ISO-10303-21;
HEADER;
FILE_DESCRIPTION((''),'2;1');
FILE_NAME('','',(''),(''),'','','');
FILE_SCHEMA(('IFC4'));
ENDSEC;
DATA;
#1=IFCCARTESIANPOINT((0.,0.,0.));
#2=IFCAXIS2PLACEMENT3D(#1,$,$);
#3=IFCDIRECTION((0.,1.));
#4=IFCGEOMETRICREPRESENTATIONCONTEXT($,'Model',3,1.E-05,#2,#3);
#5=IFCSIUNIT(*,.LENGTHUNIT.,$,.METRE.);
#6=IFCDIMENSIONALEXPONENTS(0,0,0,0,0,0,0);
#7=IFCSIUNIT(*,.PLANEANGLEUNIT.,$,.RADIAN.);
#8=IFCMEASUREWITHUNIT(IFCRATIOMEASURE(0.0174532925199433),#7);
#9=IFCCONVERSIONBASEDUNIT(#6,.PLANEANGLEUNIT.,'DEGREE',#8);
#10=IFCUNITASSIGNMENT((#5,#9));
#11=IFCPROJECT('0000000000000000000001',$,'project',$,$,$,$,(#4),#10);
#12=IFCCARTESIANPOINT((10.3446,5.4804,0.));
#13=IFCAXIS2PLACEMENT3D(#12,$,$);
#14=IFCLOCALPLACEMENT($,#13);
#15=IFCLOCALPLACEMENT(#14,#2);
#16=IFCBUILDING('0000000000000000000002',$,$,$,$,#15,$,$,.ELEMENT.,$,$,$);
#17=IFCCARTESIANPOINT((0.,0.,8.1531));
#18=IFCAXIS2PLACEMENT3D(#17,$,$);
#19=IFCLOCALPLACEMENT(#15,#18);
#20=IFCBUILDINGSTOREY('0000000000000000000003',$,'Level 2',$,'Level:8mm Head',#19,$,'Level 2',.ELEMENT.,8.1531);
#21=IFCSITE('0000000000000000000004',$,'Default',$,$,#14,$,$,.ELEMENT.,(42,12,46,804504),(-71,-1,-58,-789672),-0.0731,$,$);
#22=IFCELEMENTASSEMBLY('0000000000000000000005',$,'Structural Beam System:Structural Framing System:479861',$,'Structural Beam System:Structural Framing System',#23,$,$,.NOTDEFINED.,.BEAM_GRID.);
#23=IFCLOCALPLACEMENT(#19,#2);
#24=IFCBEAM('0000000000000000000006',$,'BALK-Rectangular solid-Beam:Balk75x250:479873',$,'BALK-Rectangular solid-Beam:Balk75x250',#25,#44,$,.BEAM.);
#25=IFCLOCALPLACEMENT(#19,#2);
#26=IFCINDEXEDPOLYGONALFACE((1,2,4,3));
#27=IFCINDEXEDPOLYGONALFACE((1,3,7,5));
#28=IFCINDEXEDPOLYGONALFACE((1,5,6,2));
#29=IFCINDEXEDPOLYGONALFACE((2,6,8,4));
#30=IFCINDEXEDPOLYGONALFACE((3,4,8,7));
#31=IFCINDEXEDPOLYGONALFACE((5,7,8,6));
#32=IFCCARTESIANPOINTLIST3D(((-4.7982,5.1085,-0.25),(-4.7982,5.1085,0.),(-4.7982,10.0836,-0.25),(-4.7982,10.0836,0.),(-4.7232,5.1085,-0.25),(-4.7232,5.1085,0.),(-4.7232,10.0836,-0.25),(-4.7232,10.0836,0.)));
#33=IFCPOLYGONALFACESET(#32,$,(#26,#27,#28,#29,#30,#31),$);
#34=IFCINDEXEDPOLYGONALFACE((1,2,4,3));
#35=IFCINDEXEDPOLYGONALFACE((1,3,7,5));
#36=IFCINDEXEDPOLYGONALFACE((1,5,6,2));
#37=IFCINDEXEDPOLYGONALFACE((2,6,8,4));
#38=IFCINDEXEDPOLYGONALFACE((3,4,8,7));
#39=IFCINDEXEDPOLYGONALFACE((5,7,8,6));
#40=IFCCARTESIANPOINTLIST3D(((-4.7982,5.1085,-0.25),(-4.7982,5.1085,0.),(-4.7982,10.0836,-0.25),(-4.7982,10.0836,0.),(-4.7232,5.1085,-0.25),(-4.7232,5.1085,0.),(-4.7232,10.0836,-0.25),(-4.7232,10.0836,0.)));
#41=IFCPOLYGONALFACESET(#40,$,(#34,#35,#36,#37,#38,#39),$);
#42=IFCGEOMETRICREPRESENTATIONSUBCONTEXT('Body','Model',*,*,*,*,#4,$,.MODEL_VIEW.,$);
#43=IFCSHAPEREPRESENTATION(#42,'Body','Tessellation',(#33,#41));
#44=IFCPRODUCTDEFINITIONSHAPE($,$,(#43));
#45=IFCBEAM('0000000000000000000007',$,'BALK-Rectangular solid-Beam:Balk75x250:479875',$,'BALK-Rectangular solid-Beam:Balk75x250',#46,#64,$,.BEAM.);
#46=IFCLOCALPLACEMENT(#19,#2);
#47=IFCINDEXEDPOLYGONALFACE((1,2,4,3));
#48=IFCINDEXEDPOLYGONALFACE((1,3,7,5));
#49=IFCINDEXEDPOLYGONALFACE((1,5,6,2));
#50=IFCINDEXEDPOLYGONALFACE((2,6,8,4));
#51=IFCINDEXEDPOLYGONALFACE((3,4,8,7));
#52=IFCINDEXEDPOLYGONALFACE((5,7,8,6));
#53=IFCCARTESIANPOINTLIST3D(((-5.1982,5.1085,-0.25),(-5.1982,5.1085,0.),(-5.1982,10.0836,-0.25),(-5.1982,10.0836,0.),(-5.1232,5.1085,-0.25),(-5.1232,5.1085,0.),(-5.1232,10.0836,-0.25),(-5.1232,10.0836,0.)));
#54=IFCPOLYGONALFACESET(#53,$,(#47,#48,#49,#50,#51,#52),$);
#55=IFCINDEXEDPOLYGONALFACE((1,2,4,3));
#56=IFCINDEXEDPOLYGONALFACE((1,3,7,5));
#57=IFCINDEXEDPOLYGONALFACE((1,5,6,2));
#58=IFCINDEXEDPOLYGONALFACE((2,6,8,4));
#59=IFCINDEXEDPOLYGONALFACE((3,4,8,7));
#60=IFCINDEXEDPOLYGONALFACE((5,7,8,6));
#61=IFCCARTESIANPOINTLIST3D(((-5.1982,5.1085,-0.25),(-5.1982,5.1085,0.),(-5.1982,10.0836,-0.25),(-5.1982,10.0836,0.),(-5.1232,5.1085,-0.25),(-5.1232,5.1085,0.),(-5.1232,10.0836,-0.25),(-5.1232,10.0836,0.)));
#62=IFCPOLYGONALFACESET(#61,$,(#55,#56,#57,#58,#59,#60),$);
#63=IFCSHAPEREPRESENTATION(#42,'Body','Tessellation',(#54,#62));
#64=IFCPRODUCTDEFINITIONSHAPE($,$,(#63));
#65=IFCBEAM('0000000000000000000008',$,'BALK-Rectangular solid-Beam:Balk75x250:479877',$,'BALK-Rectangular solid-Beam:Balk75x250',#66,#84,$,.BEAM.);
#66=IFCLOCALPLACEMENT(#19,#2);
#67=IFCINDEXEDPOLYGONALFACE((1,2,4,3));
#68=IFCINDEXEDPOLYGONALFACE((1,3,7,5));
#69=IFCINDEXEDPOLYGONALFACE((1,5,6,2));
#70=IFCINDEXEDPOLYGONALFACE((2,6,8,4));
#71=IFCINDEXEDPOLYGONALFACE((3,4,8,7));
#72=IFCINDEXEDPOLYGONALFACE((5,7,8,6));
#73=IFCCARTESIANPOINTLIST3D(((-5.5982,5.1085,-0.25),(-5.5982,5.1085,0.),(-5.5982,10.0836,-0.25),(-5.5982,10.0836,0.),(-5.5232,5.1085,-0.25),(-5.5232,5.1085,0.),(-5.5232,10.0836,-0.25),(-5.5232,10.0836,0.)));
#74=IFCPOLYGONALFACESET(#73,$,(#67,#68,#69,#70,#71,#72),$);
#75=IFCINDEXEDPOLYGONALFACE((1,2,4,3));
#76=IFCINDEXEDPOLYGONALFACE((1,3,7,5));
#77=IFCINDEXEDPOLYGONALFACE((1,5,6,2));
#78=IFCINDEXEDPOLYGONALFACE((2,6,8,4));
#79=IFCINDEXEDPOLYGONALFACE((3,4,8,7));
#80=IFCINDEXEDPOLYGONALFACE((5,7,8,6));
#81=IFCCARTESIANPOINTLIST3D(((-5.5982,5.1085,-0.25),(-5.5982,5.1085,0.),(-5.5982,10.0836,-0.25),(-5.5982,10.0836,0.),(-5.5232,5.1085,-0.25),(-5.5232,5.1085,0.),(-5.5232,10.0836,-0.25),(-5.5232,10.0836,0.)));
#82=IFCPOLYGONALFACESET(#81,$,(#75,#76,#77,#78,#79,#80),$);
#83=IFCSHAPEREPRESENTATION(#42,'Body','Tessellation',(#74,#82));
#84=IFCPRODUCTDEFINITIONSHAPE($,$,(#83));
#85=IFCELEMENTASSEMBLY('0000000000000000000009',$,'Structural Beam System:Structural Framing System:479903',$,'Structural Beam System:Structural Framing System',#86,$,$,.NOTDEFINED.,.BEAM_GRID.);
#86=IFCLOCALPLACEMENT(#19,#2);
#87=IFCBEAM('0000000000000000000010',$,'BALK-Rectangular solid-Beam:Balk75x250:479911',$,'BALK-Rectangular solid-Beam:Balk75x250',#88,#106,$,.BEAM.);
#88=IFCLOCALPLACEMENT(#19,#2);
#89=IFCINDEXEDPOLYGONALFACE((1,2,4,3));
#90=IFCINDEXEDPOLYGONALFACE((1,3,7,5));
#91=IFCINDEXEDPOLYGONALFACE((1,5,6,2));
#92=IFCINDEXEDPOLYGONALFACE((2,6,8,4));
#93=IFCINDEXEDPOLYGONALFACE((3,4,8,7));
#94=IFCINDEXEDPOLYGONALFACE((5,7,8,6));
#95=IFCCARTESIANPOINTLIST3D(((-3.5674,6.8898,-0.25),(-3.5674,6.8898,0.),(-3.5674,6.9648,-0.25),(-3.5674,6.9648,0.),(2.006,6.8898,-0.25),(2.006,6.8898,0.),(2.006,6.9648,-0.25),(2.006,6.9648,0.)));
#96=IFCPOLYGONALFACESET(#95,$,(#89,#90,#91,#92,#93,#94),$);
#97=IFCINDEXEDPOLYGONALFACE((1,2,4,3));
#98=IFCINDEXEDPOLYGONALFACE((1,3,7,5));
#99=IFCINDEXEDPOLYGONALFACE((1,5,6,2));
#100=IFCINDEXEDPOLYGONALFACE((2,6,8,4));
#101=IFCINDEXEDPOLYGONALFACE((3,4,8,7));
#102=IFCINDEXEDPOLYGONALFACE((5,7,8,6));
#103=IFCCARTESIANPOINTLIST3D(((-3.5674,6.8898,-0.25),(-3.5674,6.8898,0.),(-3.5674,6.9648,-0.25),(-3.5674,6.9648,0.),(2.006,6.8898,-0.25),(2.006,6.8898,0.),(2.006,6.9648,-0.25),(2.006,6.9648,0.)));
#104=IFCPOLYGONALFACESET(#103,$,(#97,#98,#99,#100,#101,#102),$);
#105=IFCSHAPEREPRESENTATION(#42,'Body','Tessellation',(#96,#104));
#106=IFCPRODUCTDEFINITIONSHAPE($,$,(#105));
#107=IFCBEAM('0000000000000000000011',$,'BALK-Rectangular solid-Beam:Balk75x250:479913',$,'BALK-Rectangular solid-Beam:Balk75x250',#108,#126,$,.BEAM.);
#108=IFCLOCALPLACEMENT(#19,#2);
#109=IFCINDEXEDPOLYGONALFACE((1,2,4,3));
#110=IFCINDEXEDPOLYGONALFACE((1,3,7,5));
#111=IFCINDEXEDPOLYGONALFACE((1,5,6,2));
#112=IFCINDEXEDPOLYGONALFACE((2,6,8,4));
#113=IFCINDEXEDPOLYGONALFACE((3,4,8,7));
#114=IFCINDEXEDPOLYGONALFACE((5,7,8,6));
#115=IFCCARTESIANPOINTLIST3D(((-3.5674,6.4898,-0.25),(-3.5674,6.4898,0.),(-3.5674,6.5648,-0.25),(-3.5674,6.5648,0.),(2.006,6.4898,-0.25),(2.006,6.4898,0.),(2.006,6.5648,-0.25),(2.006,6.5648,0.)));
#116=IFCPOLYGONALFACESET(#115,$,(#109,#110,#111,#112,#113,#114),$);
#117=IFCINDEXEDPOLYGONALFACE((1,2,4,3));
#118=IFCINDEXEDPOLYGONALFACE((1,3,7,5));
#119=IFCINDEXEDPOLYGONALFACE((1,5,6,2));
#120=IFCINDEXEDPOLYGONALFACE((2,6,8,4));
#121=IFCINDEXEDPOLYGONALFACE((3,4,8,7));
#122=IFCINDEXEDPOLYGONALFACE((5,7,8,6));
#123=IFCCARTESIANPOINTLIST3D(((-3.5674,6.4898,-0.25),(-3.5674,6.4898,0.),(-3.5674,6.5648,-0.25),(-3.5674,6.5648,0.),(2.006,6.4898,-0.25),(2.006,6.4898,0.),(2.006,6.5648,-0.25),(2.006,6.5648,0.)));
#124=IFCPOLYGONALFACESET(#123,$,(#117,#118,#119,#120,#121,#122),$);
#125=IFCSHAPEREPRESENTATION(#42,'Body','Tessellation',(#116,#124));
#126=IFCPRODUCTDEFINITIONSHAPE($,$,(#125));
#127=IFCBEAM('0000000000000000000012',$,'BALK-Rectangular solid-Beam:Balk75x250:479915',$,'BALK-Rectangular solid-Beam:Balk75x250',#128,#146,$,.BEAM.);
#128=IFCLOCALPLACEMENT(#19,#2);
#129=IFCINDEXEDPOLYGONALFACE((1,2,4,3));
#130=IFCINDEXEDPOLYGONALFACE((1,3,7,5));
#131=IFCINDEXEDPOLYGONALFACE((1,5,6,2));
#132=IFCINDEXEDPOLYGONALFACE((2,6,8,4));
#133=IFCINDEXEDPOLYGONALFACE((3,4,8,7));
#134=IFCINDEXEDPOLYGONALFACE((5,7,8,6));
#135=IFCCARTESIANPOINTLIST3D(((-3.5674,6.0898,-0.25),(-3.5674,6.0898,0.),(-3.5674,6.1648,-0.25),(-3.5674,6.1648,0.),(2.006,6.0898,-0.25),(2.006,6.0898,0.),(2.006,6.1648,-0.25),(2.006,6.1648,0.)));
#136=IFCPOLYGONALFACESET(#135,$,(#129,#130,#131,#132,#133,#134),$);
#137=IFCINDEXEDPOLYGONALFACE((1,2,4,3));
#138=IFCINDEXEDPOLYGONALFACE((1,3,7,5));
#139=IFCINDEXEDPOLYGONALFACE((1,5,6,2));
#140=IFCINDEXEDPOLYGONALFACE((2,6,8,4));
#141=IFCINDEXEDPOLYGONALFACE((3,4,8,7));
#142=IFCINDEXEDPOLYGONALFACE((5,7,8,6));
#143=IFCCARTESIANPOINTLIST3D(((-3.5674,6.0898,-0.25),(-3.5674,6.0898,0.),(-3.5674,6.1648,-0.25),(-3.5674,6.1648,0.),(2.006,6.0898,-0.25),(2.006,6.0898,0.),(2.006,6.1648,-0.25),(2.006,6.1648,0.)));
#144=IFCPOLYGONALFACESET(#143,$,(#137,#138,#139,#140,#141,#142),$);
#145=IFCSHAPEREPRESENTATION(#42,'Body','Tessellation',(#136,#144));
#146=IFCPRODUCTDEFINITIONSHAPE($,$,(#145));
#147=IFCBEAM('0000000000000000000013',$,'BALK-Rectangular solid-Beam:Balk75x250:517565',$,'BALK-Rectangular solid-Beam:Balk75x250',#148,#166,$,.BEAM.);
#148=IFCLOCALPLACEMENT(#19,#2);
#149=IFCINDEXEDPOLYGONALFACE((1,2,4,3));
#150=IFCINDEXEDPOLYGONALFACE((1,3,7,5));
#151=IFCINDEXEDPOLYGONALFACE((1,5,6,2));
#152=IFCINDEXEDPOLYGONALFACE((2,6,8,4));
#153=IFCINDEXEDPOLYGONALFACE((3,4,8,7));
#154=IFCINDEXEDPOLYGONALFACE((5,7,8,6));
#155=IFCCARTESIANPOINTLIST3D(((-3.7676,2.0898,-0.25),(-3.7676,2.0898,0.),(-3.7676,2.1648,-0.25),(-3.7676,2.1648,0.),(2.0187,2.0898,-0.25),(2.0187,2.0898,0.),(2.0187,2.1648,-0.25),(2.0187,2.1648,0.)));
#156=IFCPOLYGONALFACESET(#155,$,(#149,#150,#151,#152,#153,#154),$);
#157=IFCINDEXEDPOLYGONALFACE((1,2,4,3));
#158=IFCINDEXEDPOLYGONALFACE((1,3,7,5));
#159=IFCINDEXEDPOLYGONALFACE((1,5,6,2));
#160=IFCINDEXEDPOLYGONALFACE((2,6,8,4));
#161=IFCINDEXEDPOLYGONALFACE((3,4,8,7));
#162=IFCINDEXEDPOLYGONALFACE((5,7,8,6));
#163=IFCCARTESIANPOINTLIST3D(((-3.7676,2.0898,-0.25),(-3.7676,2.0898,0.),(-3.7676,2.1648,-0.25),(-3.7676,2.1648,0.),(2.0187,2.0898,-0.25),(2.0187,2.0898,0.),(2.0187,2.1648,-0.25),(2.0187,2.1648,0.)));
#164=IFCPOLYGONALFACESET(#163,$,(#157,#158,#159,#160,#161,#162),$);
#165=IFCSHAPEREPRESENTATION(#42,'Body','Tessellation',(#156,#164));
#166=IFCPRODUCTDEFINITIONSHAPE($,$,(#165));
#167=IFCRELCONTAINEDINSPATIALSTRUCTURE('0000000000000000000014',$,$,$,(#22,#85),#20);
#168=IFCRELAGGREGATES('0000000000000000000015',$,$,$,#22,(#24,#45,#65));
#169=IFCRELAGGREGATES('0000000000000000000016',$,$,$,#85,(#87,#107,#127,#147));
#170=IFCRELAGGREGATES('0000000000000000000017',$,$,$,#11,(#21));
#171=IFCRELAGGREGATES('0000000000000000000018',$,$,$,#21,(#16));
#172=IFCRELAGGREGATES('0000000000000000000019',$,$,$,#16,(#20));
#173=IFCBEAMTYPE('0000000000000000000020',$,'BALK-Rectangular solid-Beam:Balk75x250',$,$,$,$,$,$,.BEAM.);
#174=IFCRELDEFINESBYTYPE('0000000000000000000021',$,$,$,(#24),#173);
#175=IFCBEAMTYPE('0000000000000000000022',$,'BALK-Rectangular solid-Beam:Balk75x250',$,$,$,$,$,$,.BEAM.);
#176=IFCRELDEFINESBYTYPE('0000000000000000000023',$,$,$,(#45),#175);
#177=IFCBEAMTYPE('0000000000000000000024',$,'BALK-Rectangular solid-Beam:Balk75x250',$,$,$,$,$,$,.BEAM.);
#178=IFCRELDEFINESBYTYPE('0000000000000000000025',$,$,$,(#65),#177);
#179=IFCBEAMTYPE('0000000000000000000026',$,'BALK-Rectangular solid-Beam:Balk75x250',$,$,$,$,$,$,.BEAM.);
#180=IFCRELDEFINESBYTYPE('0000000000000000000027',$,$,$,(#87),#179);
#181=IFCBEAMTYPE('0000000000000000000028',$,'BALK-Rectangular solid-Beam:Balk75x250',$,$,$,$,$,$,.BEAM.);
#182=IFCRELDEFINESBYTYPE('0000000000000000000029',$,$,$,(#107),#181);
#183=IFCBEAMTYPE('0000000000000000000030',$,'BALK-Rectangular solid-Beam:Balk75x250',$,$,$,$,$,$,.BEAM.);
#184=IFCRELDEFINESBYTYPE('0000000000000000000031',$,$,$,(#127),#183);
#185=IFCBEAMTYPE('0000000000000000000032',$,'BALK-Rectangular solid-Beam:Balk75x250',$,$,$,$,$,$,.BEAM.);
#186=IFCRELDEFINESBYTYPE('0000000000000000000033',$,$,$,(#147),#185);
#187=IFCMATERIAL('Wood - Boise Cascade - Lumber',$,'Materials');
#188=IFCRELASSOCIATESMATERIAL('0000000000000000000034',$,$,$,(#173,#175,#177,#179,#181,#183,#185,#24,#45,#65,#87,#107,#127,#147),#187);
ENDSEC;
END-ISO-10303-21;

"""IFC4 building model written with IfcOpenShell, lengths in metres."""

from ifc_helpers import new_model, entity, si_unit, converted_unit, direction, frame, frame_2d, origin, origin_2d_with_axis, place, context, subcontext, project, spatial, rectangle, extrude, source, transform, mapped, material, material_profile, profile_set, profile_usage, type_object, type_shapes, element, aggregate, save


model = new_model("IFC4")

# Units and contexts
model_context = context("Model", 3, precision=1e-05, world=origin(), true_north=direction((0.0, 1.0)))
body_context = subcontext(model_context, "Body", "Model", "MODEL_VIEW")
ifc_project = project(units=[si_unit("LENGTHUNIT", "METRE"), converted_unit("PLANEANGLEUNIT", "DEGREE", entity("IfcRatioMeasure", 0.0174532925199433), si_unit("PLANEANGLEUNIT", "RADIAN"), dimensions=[0, 0, 0, 0, 0, 0, 0])], contexts=[model_context])

# Site, building, storey
site_placement = place(None, frame((10.3446, 5.4804, 0.0)))
site = spatial("IfcSite", under=ifc_project, at=site_placement, Name="Default", CompositionType="ELEMENT", RefLatitude=(42, 12, 46, 804504), RefLongitude=(-71, -1, -58, -789672), RefElevation=-0.0731)
building_placement = place(site_placement, origin())
building = spatial("IfcBuilding", under=site, at=building_placement, CompositionType="ELEMENT")
storey_placement = place(building_placement, frame((0.0, 0.0, 8.1531)))
storey = spatial("IfcBuildingStorey", under=building, at=storey_placement, Name="Level 2", ObjectType="Level:8mm Head", LongName="Level 2", CompositionType="ELEMENT", Elevation=8.1531)

# Element assemblies, beams
ifc_material = material(Name="Wood - Boise Cascade - Lumber", Category="Materials")
ifc_material_profile = material_profile(ifc_material, rectangle(XDim=0.25, YDim=0.075, at=frame_2d((0.0, 0.0), x_axis=(1.0, 0.0))), Name="Balk75x250")
ifc_profile_set = profile_set([ifc_material_profile], Name="Balk75x250")
assembly_1_placement = place(storey_placement, origin())
assembly_1 = element("IfcElementAssembly", 1, at=assembly_1_placement, inside=storey, Name="Structural Beam System:Structural Framing System:479861", ObjectType="Structural Beam System:Structural Framing System", AssemblyPlace="NOTDEFINED", PredefinedType="BEAM_GRID")
ifc_profile_usage_1 = profile_usage(ifc_profile_set, cardinal=8)
beam_type_1 = type_object("IfcBeamType", Name="BALK-Rectangular solid-Beam:Balk75x250", PredefinedType="BEAM", material=ifc_profile_set)
shared_shape_1 = source(origin(), body_context, "Body", "SweptSolid", [
    extrude(rectangle(XDim=0.25, YDim=0.075, at=frame_2d((0.0, 0.0), x_axis=(0.0, 1.0))), frame((-4.7607, 10.0836, 8.0281), z_axis=(0.0, -1.0, 0.0), x_axis=(-1.0, 0.0, 0.0)), (0.0, 0.0, 1.0), 4.9751),
    extrude(rectangle(XDim=0.25, YDim=0.075, at=frame_2d((0.0, 0.0), x_axis=(0.0, 1.0))), frame((-4.7607, 10.0836, 8.0281), z_axis=(0.0, -1.0, 0.0), x_axis=(-1.0, 0.0, 0.0)), (0.0, 0.0, 1.0), 4.9751),
])
type_shapes(beam_type_1, [shared_shape_1])
beam_1_placement = place(assembly_1_placement, frame((0.0, 0.0, -8.1531)))
beam_1 = element("IfcBeam", 2, at=beam_1_placement, type_object=beam_type_1, material=ifc_profile_usage_1, Name="BALK-Rectangular solid-Beam:Balk75x250:479873", ObjectType="BALK-Rectangular solid-Beam:Balk75x250", PredefinedType="BEAM", context=body_context, shape_type="MappedRepresentation", body=[
    mapped(shared_shape_1, transform((0.0, 0.0, 0.0), scale=1.0)),
])
ifc_profile_usage_2 = profile_usage(ifc_profile_set, cardinal=8)
beam_type_2 = type_object("IfcBeamType", Name="BALK-Rectangular solid-Beam:Balk75x250", PredefinedType="BEAM", material=ifc_profile_set)
shared_shape_2 = source(origin(), body_context, "Body", "SweptSolid", [
    extrude(rectangle(XDim=0.25, YDim=0.075, at=frame_2d((0.0, 0.0), x_axis=(0.0, 1.0))), frame((-5.1607, 10.0836, 8.0281), z_axis=(0.0, -1.0, 0.0), x_axis=(-1.0, 0.0, 0.0)), (0.0, 0.0, 1.0), 4.9751),
    extrude(rectangle(XDim=0.25, YDim=0.075, at=frame_2d((0.0, 0.0), x_axis=(0.0, 1.0))), frame((-5.1607, 10.0836, 8.0281), z_axis=(0.0, -1.0, 0.0), x_axis=(-1.0, 0.0, 0.0)), (0.0, 0.0, 1.0), 4.9751),
])
type_shapes(beam_type_2, [shared_shape_2])
beam_2_placement = place(assembly_1_placement, frame((0.0, 0.0, -8.1531)))
beam_2 = element("IfcBeam", 3, at=beam_2_placement, type_object=beam_type_2, material=ifc_profile_usage_2, Name="BALK-Rectangular solid-Beam:Balk75x250:479875", ObjectType="BALK-Rectangular solid-Beam:Balk75x250", PredefinedType="BEAM", context=body_context, shape_type="MappedRepresentation", body=[
    mapped(shared_shape_2, transform((0.0, 0.0, 0.0), scale=1.0)),
])
ifc_profile_usage_3 = profile_usage(ifc_profile_set, cardinal=8)
beam_type_3 = type_object("IfcBeamType", Name="BALK-Rectangular solid-Beam:Balk75x250", PredefinedType="BEAM", material=ifc_profile_set)
shared_shape_3 = source(origin(), body_context, "Body", "SweptSolid", [
    extrude(rectangle(XDim=0.25, YDim=0.075, at=frame_2d((0.0, 0.0), x_axis=(0.0, 1.0))), frame((-5.5607, 10.0836, 8.0281), z_axis=(0.0, -1.0, 0.0), x_axis=(-1.0, 0.0, 0.0)), (0.0, 0.0, 1.0), 4.9751),
    extrude(rectangle(XDim=0.25, YDim=0.075, at=frame_2d((0.0, 0.0), x_axis=(0.0, 1.0))), frame((-5.5607, 10.0836, 8.0281), z_axis=(0.0, -1.0, 0.0), x_axis=(-1.0, 0.0, 0.0)), (0.0, 0.0, 1.0), 4.9751),
])
type_shapes(beam_type_3, [shared_shape_3])
beam_3_placement = place(assembly_1_placement, frame((0.0, 0.0, -8.1531)))
beam_3 = element("IfcBeam", 4, at=beam_3_placement, type_object=beam_type_3, material=ifc_profile_usage_3, Name="BALK-Rectangular solid-Beam:Balk75x250:479877", ObjectType="BALK-Rectangular solid-Beam:Balk75x250", PredefinedType="BEAM", context=body_context, shape_type="MappedRepresentation", body=[
    mapped(shared_shape_3, transform((0.0, 0.0, 0.0), scale=1.0)),
])
aggregate(assembly_1, [beam_1, beam_2, beam_3])
assembly_2_placement = place(storey_placement, origin())
assembly_2 = element("IfcElementAssembly", 5, at=assembly_2_placement, inside=storey, Name="Structural Beam System:Structural Framing System:479903", ObjectType="Structural Beam System:Structural Framing System", AssemblyPlace="NOTDEFINED", PredefinedType="BEAM_GRID")
ifc_profile_usage_4 = profile_usage(ifc_profile_set, cardinal=8)
beam_type_4 = type_object("IfcBeamType", Name="BALK-Rectangular solid-Beam:Balk75x250", PredefinedType="BEAM", material=ifc_profile_set)
shared_shape_4 = source(origin(), body_context, "Body", "SweptSolid", [
    extrude(rectangle(XDim=0.25, YDim=0.075, at=frame_2d((0.0, 0.0), x_axis=(1.0, 0.0))), frame((-3.5674, 6.9273, 8.0281), z_axis=(1.0, 0.0, 0.0), x_axis=(0.0, 0.0, -1.0)), (0.0, 0.0, 1.0), 5.5734),
    extrude(rectangle(XDim=0.25, YDim=0.075, at=frame_2d((0.0, 0.0), x_axis=(1.0, 0.0))), frame((-3.5674, 6.9273, 8.0281), z_axis=(1.0, 0.0, 0.0), x_axis=(0.0, 0.0, -1.0)), (0.0, 0.0, 1.0), 5.5734),
])
type_shapes(beam_type_4, [shared_shape_4])
beam_4_placement = place(assembly_2_placement, frame((0.0, 0.0, -8.1531)))
beam_4 = element("IfcBeam", 6, at=beam_4_placement, type_object=beam_type_4, material=ifc_profile_usage_4, Name="BALK-Rectangular solid-Beam:Balk75x250:479911", ObjectType="BALK-Rectangular solid-Beam:Balk75x250", PredefinedType="BEAM", context=body_context, shape_type="MappedRepresentation", body=[
    mapped(shared_shape_4, transform((0.0, 0.0, 0.0), scale=1.0)),
])
ifc_profile_usage_5 = profile_usage(ifc_profile_set, cardinal=8)
beam_type_5 = type_object("IfcBeamType", Name="BALK-Rectangular solid-Beam:Balk75x250", PredefinedType="BEAM", material=ifc_profile_set)
shared_shape_5 = source(origin(), body_context, "Body", "SweptSolid", [
    extrude(rectangle(XDim=0.25, YDim=0.075, at=frame_2d((0.0, 0.0), x_axis=(1.0, 0.0))), frame((-3.5674, 6.5273, 8.0281), z_axis=(1.0, 0.0, 0.0), x_axis=(0.0, 0.0, -1.0)), (0.0, 0.0, 1.0), 5.5734),
    extrude(rectangle(XDim=0.25, YDim=0.075, at=frame_2d((0.0, 0.0), x_axis=(1.0, 0.0))), frame((-3.5674, 6.5273, 8.0281), z_axis=(1.0, 0.0, 0.0), x_axis=(0.0, 0.0, -1.0)), (0.0, 0.0, 1.0), 5.5734),
])
type_shapes(beam_type_5, [shared_shape_5])
beam_5_placement = place(assembly_2_placement, frame((0.0, 0.0, -8.1531)))
beam_5 = element("IfcBeam", 7, at=beam_5_placement, type_object=beam_type_5, material=ifc_profile_usage_5, Name="BALK-Rectangular solid-Beam:Balk75x250:479913", ObjectType="BALK-Rectangular solid-Beam:Balk75x250", PredefinedType="BEAM", context=body_context, shape_type="MappedRepresentation", body=[
    mapped(shared_shape_5, transform((0.0, 0.0, 0.0), scale=1.0)),
])
ifc_profile_usage_6 = profile_usage(ifc_profile_set, cardinal=8)
beam_type_6 = type_object("IfcBeamType", Name="BALK-Rectangular solid-Beam:Balk75x250", PredefinedType="BEAM", material=ifc_profile_set)
shared_shape_6 = source(origin(), body_context, "Body", "SweptSolid", [
    extrude(rectangle(XDim=0.25, YDim=0.075, at=frame_2d((0.0, 0.0), x_axis=(1.0, 0.0))), frame((-3.5674, 6.1273, 8.0281), z_axis=(1.0, 0.0, 0.0), x_axis=(0.0, 0.0, -1.0)), (0.0, 0.0, 1.0), 5.5734),
    extrude(rectangle(XDim=0.25, YDim=0.075, at=frame_2d((0.0, 0.0), x_axis=(1.0, 0.0))), frame((-3.5674, 6.1273, 8.0281), z_axis=(1.0, 0.0, 0.0), x_axis=(0.0, 0.0, -1.0)), (0.0, 0.0, 1.0), 5.5734),
])
type_shapes(beam_type_6, [shared_shape_6])
beam_6_placement = place(assembly_2_placement, frame((0.0, 0.0, -8.1531)))
beam_6 = element("IfcBeam", 8, at=beam_6_placement, type_object=beam_type_6, material=ifc_profile_usage_6, Name="BALK-Rectangular solid-Beam:Balk75x250:479915", ObjectType="BALK-Rectangular solid-Beam:Balk75x250", PredefinedType="BEAM", context=body_context, shape_type="MappedRepresentation", body=[
    mapped(shared_shape_6, transform((0.0, 0.0, 0.0), scale=1.0)),
])
ifc_profile_usage_7 = profile_usage(ifc_profile_set, cardinal=8)
beam_type_7 = type_object("IfcBeamType", Name="BALK-Rectangular solid-Beam:Balk75x250", PredefinedType="BEAM", material=ifc_profile_set)
shared_shape_7 = source(origin(), body_context, "Body", "SweptSolid", [
    extrude(rectangle(XDim=0.25, YDim=0.075, at=origin_2d_with_axis()), frame((-2.9869, 0.0, 0.0), z_axis=(1.0, 0.0, 0.0), x_axis=(0.0, 0.0, -1.0)), (0.0, 0.0, 1.0), 5.7863),
    extrude(rectangle(XDim=0.25, YDim=0.075, at=origin_2d_with_axis()), frame((-2.9869, 0.0, 0.0), z_axis=(1.0, 0.0, 0.0), x_axis=(0.0, 0.0, -1.0)), (0.0, 0.0, 1.0), 5.7863),
])
type_shapes(beam_type_7, [shared_shape_7])
beam_7_placement = place(assembly_2_placement, frame((-0.7807, 2.1273, -0.125)))
beam_7 = element("IfcBeam", 9, at=beam_7_placement, type_object=beam_type_7, material=ifc_profile_usage_7, Name="BALK-Rectangular solid-Beam:Balk75x250:517565", ObjectType="BALK-Rectangular solid-Beam:Balk75x250", PredefinedType="BEAM", context=body_context, shape_type="MappedRepresentation", body=[
    mapped(shared_shape_7, transform((0.0, 0.0, 0.0), scale=1.0)),
])
aggregate(assembly_2, [beam_4, beam_5, beam_6, beam_7])

save(model, "model.ifc")
